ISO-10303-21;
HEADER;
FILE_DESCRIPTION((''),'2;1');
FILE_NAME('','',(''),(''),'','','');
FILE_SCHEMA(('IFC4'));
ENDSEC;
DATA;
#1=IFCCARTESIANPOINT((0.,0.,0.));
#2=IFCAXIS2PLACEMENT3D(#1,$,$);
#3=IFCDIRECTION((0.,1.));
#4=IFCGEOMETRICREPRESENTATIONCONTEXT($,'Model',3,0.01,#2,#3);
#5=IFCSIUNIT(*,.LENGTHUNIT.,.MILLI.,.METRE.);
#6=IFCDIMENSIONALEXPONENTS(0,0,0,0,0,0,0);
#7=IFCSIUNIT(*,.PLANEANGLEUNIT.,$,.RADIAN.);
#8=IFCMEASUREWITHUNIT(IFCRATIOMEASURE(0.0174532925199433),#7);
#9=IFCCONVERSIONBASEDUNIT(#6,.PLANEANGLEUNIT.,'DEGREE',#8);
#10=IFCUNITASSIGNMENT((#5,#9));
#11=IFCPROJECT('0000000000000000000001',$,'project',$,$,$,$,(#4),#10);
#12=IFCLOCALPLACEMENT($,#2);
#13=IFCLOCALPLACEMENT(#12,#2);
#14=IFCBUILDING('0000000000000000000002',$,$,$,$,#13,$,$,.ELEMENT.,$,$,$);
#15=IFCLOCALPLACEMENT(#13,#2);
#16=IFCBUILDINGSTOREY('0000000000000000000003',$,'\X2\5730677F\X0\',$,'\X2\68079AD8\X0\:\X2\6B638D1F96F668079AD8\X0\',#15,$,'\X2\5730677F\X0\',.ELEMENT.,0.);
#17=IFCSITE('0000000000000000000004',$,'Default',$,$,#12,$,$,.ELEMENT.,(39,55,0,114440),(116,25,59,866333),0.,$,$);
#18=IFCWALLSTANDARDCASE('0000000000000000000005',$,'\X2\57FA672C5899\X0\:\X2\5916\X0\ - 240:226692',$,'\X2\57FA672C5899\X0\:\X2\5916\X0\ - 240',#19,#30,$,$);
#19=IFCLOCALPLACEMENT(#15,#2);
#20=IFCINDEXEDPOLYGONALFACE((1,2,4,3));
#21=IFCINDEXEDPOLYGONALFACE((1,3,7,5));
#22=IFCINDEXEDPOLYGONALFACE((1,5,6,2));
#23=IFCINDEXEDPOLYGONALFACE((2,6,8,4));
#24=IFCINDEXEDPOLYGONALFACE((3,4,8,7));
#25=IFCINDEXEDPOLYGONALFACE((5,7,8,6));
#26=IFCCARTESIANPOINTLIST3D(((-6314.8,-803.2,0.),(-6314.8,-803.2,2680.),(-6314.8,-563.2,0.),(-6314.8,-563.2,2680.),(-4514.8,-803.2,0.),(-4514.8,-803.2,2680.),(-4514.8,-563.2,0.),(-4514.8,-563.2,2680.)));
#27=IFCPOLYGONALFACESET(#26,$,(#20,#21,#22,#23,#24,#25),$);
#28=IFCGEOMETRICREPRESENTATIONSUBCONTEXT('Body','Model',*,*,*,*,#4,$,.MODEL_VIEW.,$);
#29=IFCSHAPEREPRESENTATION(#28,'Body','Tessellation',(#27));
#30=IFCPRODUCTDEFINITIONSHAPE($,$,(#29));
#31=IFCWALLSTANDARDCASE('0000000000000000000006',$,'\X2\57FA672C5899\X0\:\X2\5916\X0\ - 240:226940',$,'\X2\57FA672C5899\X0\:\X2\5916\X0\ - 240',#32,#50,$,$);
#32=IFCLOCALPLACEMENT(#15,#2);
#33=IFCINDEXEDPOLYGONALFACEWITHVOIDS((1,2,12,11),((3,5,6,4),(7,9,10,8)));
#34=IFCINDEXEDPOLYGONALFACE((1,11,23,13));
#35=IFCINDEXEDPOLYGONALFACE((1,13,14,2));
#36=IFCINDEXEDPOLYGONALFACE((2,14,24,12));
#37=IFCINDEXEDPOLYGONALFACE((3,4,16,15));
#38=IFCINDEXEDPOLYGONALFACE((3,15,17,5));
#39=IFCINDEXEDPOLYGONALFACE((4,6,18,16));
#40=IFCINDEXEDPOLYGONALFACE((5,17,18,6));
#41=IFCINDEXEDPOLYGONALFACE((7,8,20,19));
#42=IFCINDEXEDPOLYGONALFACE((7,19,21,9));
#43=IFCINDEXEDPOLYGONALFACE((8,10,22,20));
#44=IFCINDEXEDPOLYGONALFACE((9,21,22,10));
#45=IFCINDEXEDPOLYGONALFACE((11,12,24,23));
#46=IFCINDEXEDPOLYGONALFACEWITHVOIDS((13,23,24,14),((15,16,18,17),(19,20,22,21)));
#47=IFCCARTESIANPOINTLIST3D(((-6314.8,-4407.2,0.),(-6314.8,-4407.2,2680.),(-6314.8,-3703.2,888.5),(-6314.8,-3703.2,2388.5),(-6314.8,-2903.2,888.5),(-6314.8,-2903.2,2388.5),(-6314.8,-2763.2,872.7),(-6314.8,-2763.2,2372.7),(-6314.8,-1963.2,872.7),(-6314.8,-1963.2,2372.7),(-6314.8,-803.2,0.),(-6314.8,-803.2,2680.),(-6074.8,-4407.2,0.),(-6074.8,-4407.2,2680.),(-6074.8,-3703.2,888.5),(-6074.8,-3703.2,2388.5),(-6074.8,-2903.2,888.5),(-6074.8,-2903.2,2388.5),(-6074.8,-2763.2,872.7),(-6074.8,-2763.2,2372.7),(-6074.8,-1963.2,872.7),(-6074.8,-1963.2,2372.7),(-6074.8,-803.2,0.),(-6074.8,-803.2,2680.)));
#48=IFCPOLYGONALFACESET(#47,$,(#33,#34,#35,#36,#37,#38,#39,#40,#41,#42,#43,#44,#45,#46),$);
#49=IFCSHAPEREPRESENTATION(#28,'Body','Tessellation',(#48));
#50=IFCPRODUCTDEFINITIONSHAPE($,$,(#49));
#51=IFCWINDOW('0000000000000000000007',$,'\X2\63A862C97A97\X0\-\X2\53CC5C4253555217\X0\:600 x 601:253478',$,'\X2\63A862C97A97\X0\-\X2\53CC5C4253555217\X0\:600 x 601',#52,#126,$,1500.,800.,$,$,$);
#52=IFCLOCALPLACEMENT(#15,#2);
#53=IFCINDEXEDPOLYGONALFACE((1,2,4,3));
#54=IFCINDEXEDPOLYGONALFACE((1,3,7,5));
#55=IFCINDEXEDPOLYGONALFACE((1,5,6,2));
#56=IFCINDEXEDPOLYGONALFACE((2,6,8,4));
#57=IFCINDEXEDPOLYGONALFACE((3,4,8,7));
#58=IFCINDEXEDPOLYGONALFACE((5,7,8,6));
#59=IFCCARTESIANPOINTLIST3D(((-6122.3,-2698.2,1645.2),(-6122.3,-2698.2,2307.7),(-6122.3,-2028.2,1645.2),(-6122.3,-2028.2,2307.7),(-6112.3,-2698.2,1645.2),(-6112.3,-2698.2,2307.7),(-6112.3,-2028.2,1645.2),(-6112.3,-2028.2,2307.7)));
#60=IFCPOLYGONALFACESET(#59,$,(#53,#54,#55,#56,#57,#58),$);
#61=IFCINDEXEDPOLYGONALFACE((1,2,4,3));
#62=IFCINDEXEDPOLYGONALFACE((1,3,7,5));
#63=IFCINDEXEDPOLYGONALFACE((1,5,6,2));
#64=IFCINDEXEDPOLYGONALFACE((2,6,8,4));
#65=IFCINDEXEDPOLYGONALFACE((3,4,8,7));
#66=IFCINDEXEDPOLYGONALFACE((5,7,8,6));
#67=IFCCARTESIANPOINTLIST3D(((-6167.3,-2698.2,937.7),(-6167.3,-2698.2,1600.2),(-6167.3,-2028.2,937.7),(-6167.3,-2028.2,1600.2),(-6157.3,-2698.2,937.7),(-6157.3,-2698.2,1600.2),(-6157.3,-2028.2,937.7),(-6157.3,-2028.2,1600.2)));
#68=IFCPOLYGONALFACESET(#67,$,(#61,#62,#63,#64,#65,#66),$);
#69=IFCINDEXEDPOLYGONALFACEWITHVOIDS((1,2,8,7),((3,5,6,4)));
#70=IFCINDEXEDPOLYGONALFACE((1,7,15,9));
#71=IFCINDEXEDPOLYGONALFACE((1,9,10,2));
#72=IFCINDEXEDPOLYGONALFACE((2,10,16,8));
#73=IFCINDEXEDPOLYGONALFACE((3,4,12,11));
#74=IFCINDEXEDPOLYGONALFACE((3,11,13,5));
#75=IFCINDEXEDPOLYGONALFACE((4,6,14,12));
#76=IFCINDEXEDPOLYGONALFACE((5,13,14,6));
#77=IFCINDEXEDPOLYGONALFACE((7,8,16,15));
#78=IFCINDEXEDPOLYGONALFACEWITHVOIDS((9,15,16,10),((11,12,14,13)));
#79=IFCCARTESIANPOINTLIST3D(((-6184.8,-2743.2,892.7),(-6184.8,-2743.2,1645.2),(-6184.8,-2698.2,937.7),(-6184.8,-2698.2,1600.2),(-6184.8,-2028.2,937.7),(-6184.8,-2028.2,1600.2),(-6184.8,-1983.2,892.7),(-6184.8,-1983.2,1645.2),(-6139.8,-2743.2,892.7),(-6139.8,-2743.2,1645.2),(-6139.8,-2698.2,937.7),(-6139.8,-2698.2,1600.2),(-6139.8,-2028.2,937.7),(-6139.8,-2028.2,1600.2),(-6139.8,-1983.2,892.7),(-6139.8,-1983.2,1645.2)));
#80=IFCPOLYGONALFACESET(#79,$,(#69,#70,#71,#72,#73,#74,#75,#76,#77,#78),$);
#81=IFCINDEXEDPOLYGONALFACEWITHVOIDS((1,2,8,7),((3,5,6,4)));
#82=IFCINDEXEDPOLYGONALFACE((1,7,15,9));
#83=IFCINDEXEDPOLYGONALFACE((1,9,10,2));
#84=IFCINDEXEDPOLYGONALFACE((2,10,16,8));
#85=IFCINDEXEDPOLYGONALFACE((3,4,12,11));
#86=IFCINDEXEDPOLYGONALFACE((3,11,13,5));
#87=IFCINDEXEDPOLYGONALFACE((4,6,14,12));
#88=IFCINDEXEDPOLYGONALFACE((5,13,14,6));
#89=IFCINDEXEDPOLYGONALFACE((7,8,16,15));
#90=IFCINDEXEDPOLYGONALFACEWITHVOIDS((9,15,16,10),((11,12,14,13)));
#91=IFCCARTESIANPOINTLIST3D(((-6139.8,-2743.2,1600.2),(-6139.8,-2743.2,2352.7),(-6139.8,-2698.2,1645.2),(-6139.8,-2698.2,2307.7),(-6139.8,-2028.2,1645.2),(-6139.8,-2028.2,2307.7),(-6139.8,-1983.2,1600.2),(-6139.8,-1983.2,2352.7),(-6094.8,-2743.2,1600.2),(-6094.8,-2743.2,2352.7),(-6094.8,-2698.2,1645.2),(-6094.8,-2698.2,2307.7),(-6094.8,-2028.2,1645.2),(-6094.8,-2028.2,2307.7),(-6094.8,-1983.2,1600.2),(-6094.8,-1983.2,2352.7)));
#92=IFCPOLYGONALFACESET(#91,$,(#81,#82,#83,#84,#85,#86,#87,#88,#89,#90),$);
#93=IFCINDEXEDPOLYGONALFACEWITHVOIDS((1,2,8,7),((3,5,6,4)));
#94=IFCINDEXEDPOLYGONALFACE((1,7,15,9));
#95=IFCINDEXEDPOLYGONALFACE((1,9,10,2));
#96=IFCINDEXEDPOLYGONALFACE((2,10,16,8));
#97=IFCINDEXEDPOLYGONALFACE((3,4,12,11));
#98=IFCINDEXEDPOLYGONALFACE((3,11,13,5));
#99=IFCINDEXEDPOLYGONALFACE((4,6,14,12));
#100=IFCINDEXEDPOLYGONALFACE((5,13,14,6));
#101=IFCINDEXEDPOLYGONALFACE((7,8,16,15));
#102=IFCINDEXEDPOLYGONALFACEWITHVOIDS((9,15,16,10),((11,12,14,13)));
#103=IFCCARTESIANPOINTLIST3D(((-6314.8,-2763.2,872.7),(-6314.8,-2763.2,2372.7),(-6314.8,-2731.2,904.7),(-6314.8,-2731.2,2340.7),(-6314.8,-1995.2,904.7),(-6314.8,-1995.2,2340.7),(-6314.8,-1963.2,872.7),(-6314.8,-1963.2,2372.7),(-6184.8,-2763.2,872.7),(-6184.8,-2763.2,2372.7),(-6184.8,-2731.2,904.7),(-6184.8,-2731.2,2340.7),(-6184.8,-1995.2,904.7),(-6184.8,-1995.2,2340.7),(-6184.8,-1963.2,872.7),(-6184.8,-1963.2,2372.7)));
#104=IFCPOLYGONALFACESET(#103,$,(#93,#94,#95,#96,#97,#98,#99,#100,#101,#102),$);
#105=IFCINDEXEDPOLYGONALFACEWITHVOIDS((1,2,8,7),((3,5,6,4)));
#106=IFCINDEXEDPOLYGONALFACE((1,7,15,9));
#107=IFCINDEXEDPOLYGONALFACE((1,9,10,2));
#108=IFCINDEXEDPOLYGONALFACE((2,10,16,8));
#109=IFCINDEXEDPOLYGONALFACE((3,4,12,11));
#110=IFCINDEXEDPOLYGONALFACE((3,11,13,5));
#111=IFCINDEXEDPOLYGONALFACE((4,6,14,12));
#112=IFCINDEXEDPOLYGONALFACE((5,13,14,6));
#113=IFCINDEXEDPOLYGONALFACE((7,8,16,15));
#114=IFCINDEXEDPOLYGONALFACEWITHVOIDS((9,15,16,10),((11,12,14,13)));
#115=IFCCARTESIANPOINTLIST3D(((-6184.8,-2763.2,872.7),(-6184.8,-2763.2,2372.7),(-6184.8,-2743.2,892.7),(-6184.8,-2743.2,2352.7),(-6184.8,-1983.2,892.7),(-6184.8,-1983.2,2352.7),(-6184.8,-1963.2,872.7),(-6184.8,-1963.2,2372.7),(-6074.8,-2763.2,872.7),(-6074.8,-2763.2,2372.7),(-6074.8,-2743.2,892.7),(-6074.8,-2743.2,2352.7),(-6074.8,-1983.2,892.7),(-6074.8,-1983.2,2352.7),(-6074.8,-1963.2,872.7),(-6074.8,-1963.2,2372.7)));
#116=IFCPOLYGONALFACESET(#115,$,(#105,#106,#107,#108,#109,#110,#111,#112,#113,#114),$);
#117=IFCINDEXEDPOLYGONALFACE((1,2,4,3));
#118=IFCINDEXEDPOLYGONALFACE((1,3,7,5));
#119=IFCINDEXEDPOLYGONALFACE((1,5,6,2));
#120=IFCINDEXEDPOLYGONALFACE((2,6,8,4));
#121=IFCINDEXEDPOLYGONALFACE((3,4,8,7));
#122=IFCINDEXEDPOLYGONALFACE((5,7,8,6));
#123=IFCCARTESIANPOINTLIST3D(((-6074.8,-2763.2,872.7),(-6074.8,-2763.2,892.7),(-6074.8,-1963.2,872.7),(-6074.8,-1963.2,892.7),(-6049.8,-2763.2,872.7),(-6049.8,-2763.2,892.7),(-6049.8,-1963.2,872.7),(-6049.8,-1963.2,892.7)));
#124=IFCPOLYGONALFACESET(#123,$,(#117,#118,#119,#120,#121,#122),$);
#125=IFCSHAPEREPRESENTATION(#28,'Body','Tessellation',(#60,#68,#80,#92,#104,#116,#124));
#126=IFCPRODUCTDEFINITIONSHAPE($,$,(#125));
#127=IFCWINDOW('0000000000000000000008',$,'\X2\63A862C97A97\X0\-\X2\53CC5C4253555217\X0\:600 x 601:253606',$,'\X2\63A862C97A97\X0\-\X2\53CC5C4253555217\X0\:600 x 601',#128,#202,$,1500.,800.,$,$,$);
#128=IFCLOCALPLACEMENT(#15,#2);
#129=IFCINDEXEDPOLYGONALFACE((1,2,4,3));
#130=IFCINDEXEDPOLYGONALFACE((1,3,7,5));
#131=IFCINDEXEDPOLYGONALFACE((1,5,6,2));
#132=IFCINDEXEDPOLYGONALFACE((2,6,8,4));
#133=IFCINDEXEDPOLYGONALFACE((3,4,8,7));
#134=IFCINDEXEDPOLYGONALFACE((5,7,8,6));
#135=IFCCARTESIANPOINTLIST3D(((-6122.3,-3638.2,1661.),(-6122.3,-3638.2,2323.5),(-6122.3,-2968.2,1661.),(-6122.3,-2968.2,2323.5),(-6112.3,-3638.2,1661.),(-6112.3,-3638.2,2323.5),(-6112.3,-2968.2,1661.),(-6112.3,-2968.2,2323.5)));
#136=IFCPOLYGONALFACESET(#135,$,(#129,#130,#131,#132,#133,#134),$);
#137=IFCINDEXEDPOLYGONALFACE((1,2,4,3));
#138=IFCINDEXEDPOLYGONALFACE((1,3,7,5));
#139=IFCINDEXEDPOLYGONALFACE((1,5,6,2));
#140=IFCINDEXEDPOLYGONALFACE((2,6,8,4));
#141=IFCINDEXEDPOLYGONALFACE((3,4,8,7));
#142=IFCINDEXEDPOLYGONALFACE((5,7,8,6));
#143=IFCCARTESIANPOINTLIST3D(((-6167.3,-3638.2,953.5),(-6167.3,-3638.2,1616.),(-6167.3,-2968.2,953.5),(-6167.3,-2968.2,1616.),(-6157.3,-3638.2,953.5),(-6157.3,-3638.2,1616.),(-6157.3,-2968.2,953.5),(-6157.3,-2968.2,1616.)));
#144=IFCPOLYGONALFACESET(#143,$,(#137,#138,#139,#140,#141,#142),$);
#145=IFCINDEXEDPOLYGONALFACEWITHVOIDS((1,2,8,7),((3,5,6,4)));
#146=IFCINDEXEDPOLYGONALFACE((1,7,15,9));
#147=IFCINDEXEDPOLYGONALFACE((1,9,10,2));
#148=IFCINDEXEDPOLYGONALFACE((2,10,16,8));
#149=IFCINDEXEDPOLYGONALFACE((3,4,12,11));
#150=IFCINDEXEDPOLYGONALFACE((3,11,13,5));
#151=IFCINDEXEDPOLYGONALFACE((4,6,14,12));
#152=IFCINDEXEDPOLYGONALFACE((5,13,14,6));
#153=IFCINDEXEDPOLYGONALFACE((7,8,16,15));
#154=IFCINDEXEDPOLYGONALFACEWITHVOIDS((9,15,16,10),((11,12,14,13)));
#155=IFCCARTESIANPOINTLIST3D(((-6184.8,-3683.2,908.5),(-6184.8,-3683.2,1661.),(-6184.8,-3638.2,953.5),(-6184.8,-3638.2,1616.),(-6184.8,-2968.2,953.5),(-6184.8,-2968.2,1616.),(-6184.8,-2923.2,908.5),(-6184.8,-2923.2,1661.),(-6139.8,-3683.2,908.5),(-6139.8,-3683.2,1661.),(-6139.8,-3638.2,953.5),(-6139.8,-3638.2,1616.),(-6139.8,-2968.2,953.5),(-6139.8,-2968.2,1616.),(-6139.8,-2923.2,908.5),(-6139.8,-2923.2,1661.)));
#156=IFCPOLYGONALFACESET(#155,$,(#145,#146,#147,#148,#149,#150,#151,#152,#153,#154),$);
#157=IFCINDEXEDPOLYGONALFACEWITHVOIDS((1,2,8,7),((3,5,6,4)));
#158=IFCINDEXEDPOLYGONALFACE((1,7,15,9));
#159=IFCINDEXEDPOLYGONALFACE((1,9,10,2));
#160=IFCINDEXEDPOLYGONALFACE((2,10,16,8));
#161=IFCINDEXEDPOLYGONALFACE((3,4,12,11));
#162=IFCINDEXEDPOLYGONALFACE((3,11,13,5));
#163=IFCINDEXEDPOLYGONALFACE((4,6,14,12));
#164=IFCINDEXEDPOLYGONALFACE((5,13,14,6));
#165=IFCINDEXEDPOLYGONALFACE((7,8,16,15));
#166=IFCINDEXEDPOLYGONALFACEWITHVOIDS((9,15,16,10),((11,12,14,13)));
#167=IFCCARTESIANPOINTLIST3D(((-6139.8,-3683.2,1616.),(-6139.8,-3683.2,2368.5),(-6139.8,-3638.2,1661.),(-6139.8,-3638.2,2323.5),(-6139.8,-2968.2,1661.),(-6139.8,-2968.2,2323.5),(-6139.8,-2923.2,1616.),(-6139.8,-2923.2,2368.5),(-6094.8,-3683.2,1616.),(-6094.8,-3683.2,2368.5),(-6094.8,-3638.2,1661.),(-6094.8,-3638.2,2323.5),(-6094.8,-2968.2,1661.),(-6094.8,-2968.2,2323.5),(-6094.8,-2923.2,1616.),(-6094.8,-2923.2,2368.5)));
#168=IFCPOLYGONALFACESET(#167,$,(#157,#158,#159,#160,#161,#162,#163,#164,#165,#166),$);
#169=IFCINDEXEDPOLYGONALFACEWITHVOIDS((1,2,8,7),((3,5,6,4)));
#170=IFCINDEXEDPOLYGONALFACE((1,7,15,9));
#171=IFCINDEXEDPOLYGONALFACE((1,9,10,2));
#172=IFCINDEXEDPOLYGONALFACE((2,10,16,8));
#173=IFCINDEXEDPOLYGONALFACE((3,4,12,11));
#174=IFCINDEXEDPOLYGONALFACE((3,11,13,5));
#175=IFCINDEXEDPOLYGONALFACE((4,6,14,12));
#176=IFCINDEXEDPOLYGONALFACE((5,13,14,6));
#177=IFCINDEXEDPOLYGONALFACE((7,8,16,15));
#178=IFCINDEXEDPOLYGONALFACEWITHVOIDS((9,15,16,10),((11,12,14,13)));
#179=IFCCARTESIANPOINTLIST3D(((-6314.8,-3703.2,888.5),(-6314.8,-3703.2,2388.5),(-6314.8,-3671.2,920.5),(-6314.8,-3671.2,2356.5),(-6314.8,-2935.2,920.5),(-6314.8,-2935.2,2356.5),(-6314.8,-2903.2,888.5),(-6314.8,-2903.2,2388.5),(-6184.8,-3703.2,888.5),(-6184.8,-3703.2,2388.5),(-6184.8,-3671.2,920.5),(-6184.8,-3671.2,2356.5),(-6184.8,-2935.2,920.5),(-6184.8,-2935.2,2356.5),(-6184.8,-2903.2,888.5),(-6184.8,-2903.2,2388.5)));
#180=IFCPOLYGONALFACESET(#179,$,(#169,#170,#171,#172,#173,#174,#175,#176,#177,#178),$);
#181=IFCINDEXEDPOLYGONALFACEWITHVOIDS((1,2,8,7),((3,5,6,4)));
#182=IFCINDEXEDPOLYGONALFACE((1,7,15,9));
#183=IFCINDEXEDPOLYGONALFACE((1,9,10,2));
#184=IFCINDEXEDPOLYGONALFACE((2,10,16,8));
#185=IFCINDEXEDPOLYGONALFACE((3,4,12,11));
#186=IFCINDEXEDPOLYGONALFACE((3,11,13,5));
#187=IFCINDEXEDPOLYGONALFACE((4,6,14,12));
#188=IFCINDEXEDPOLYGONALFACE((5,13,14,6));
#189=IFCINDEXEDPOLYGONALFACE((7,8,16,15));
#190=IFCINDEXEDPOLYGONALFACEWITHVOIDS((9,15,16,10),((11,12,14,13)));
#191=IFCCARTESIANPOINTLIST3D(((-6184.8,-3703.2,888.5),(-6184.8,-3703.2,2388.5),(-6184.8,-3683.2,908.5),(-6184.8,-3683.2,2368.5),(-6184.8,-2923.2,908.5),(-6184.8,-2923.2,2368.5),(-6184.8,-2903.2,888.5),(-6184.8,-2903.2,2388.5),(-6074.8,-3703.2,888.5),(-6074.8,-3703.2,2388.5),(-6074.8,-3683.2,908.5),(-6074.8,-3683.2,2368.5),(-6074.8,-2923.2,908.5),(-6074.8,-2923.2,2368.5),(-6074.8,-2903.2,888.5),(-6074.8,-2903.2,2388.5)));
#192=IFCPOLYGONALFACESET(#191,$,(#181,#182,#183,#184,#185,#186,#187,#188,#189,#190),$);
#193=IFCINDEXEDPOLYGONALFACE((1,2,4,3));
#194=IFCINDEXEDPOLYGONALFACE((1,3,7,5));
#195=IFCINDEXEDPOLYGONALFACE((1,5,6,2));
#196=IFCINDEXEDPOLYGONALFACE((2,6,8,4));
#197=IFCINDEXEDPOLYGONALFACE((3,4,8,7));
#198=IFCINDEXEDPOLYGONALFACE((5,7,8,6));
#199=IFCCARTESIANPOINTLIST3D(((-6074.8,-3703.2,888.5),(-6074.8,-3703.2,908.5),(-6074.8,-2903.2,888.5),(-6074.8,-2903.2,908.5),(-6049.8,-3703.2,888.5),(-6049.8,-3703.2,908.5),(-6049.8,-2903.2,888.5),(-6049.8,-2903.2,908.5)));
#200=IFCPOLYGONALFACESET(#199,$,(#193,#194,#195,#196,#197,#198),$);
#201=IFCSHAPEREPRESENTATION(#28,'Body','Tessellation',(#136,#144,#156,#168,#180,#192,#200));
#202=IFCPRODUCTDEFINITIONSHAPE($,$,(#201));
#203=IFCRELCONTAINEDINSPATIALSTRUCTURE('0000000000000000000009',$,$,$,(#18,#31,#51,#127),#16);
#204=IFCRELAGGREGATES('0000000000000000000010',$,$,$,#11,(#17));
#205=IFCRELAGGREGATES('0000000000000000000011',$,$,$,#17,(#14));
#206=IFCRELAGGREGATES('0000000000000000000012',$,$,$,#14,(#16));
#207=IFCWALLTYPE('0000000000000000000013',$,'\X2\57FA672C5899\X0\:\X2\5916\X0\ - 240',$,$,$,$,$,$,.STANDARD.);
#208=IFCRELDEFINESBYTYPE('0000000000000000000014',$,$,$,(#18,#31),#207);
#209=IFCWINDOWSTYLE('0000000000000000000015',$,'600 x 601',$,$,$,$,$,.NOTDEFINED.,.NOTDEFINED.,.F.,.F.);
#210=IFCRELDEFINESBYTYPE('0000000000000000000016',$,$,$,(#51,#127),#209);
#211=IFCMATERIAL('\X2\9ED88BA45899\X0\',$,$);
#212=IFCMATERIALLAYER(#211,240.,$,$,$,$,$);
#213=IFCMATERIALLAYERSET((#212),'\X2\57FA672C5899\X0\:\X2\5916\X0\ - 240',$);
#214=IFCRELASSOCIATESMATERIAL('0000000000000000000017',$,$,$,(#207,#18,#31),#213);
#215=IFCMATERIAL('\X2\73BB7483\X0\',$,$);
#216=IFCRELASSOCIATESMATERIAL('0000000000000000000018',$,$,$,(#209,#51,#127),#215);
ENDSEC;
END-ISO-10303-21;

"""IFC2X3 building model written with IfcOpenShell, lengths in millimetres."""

from ifc_helpers import new_model, entity, si_unit, converted_unit, direction, frame, frame_2d, origin, origin_2d_with_axis, place, context, subcontext, project, spatial, polyline, rectangle, outline, extrude, source, transform, mapped, material, layer, layer_set, layer_usage, type_object, type_shapes, element, fill, save


model = new_model("IFC2X3")

# Units and contexts
model_context = context("Model", 3, precision=0.01, world=origin(), true_north=direction((0.0, 1.0)))
body_context = subcontext(model_context, "Body", "Model", "MODEL_VIEW")
ifc_project = project(units=[si_unit("LENGTHUNIT", "METRE", prefix="MILLI"), converted_unit("PLANEANGLEUNIT", "DEGREE", entity("IfcRatioMeasure", 0.0174532925199433), si_unit("PLANEANGLEUNIT", "RADIAN"), dimensions=[0, 0, 0, 0, 0, 0, 0])], contexts=[model_context])

# Site, building, storey
site_placement = place(None, origin())
site = spatial("IfcSite", under=ifc_project, at=site_placement, Name="Default", CompositionType="ELEMENT", RefLatitude=(39, 55, 0, 114440), RefLongitude=(116, 25, 59, 866333), RefElevation=0.0)
building_placement = place(site_placement, origin())
building = spatial("IfcBuilding", under=site, at=building_placement, CompositionType="ELEMENT")
storey_placement = place(building_placement, origin())
storey = spatial("IfcBuildingStorey", under=building, at=storey_placement, Name="地板", ObjectType="标高:正负零标高", LongName="地板", CompositionType="ELEMENT", Elevation=0.0)

# Wall
ifc_material_1 = material(Name="默认墙")
ifc_layer_1 = layer(ifc_material_1, 240.0)
ifc_layer_set_1 = layer_set([ifc_layer_1], Name="基本墙:外 - 240")
ifc_layer_usage_1 = layer_usage(ifc_layer_set_1, "AXIS2", "NEGATIVE", 120.0)
wall_type_1 = type_object("IfcWallType", Name="基本墙:外 - 240", PredefinedType="STANDARD", material=ifc_layer_set_1)
wall_1_placement = place(storey_placement, frame((-4514.8, -683.2, 0.0), z_axis=(0.0, 0.0, 1.0), x_axis=(-1.0, 0.0, 0.0)))
element("IfcWallStandardCase", 1, at=wall_1_placement, inside=storey, type_object=wall_type_1, material=ifc_layer_usage_1, Name="基本墙:外 - 240:226692", ObjectType="基本墙:外 - 240", context=body_context, shape_type="SweptSolid", body=[
    extrude(rectangle(XDim=1800.0, YDim=240.0, at=frame_2d((900.0, 0.0), x_axis=(-1.0, 0.0))), origin(), (0.0, 0.0, 1.0), 2680.0),
])

# Wall, openings, windows
ifc_layer_usage_2 = layer_usage(ifc_layer_set_1, "AXIS2", "NEGATIVE", 120.0)
wall_2_placement = place(storey_placement, frame((-6194.8, -803.2, 0.0), z_axis=(0.0, 0.0, 1.0), x_axis=(0.0, -1.0, 0.0)))
wall_2 = element("IfcWallStandardCase", 2, at=wall_2_placement, inside=storey, type_object=wall_type_1, material=ifc_layer_usage_2, Name="基本墙:外 - 240:226940", ObjectType="基本墙:外 - 240", context=body_context, shape_type="SweptSolid", body=[
    extrude(rectangle(XDim=3604.0, YDim=240.0, at=frame_2d((1802.0, 0.0), x_axis=(-1.0, 0.0))), origin(), (0.0, 0.0, 1.0), 2680.0),
])
opening_1_placement = place(wall_2_placement, frame((2100.0, -120.0, 888.5)))
opening_1 = element("IfcOpeningElement", 3, at=opening_1_placement, cuts=wall_2, ObjectType="Opening", context=body_context, shape_type="SweptSolid", body=[
    extrude(rectangle(XDim=1500.0, YDim=800.0, at=frame_2d((750.0, 400.0), x_axis=(-1.0, 0.0))), frame((0.0, 0.0, 0.0), z_axis=(0.0, 1.0, 0.0), x_axis=(0.0, 0.0, 1.0)), (0.0, 0.0, 1.0), 240.0),
])
opening_2_placement = place(wall_2_placement, frame((1160.0, -120.0, 872.7)))
opening_2 = element("IfcOpeningElement", 4, at=opening_2_placement, cuts=wall_2, ObjectType="Opening", context=body_context, shape_type="SweptSolid", body=[
    extrude(rectangle(XDim=1500.0, YDim=800.0, at=frame_2d((750.0, 400.0), x_axis=(-1.0, 0.0))), frame((0.0, 0.0, 0.0), z_axis=(0.0, 1.0, 0.0), x_axis=(0.0, 0.0, 1.0)), (0.0, 0.0, 1.0), 240.0),
])
ifc_material_2 = material(Name="玻璃")
window_style_1 = type_object("IfcWindowStyle", Name="600 x 601", ConstructionType="NOTDEFINED", OperationType="NOTDEFINED", ParameterTakesPrecedence=False, Sizeable=False, material=ifc_material_2)
shared_shape_1 = source(origin(), body_context, "Body", "SweptSolid", [
    extrude(rectangle(XDim=10.0, YDim=670.0, at=origin_2d_with_axis()), frame((400.0, 197.5, 772.5), z_axis=(0.0, 0.0, 1.0), x_axis=(0.0, -1.0, 0.0)), (0.0, 0.0, 1.0), 662.5),
    extrude(rectangle(XDim=10.0, YDim=670.0, at=origin_2d_with_axis()), frame((400.0, 152.5, 65.0), z_axis=(0.0, 0.0, 1.0), x_axis=(0.0, -1.0, 0.0)), (0.0, 0.0, 1.0), 662.5),
    extrude(outline(polyline([(-380.0, -376.2), (380.0, -376.2), (380.0, 376.2), (-380.0, 376.2), (-380.0, -376.2)]), holes=[polyline([(-335.0, -331.2), (-335.0, 331.2), (335.0, 331.2), (335.0, -331.2), (-335.0, -331.2)])]), frame((400.0, 130.0, 396.3), z_axis=(0.0, 1.0, 0.0), x_axis=(1.0, 0.0, 0.0)), (0.0, 0.0, 1.0), 45.0),
    extrude(outline(polyline([(-380.0, -376.2), (380.0, -376.2), (380.0, 376.2), (-380.0, 376.2), (-380.0, -376.2)]), holes=[polyline([(-335.0, -331.2), (-335.0, 331.2), (335.0, 331.2), (335.0, -331.2), (-335.0, -331.2)])]), frame((400.0, 175.0, 1103.8), z_axis=(0.0, 1.0, 0.0), x_axis=(1.0, 0.0, 0.0)), (0.0, 0.0, 1.0), 45.0),
    extrude(outline(polyline([(-400.0, -750.0), (400.0, -750.0), (400.0, 750.0), (-400.0, 750.0), (-400.0, -750.0)]), holes=[polyline([(-368.0, -718.0), (-368.0, 718.0), (368.0, 718.0), (368.0, -718.0), (-368.0, -718.0)])]), frame((400.0, 0.0, 750.0), z_axis=(0.0, 1.0, 0.0), x_axis=(1.0, 0.0, 0.0)), (0.0, 0.0, 1.0), 130.0),
    extrude(outline(polyline([(-750.0, -400.0), (750.0, -400.0), (750.0, 400.0), (-750.0, 400.0), (-750.0, -400.0)]), holes=[polyline([(-730.0, -380.0), (-730.0, 380.0), (730.0, 380.0), (730.0, -380.0), (-730.0, -380.0)])]), frame((400.0, 130.0, 750.0), z_axis=(0.0, 1.0, 0.0), x_axis=(0.0, 0.0, -1.0)), (0.0, 0.0, 1.0), 110.0),
    extrude(rectangle(XDim=25.0, YDim=800.0, at=origin_2d_with_axis()), frame((400.0, 252.5, 0.0), z_axis=(0.0, 0.0, 1.0), x_axis=(0.0, -1.0, 0.0)), (0.0, 0.0, 1.0), 20.0),
])
type_shapes(window_style_1, [shared_shape_1])
window_1_placement = place(opening_2_placement, origin())
window_1 = element("IfcWindow", 5, at=window_1_placement, inside=storey, type_object=window_style_1, material=ifc_material_2, Name="推拉窗-双层单列:600 x 601:253478", ObjectType="推拉窗-双层单列:600 x 601", OverallHeight=1500.0, OverallWidth=800.0, context=body_context, shape_type="MappedRepresentation", body=[
    mapped(shared_shape_1, transform((0.0, 0.0, 0.0), scale=1.0)),
])
fill(opening_2, window_1)
window_2_placement = place(opening_1_placement, origin())
window_2 = element("IfcWindow", 6, at=window_2_placement, inside=storey, type_object=window_style_1, material=ifc_material_2, Name="推拉窗-双层单列:600 x 601:253606", ObjectType="推拉窗-双层单列:600 x 601", OverallHeight=1500.0, OverallWidth=800.0, context=body_context, shape_type="MappedRepresentation", body=[
    mapped(shared_shape_1, transform((0.0, 0.0, 0.0), scale=1.0)),
])
fill(opening_1, window_2)

save(model, "model.ifc")
